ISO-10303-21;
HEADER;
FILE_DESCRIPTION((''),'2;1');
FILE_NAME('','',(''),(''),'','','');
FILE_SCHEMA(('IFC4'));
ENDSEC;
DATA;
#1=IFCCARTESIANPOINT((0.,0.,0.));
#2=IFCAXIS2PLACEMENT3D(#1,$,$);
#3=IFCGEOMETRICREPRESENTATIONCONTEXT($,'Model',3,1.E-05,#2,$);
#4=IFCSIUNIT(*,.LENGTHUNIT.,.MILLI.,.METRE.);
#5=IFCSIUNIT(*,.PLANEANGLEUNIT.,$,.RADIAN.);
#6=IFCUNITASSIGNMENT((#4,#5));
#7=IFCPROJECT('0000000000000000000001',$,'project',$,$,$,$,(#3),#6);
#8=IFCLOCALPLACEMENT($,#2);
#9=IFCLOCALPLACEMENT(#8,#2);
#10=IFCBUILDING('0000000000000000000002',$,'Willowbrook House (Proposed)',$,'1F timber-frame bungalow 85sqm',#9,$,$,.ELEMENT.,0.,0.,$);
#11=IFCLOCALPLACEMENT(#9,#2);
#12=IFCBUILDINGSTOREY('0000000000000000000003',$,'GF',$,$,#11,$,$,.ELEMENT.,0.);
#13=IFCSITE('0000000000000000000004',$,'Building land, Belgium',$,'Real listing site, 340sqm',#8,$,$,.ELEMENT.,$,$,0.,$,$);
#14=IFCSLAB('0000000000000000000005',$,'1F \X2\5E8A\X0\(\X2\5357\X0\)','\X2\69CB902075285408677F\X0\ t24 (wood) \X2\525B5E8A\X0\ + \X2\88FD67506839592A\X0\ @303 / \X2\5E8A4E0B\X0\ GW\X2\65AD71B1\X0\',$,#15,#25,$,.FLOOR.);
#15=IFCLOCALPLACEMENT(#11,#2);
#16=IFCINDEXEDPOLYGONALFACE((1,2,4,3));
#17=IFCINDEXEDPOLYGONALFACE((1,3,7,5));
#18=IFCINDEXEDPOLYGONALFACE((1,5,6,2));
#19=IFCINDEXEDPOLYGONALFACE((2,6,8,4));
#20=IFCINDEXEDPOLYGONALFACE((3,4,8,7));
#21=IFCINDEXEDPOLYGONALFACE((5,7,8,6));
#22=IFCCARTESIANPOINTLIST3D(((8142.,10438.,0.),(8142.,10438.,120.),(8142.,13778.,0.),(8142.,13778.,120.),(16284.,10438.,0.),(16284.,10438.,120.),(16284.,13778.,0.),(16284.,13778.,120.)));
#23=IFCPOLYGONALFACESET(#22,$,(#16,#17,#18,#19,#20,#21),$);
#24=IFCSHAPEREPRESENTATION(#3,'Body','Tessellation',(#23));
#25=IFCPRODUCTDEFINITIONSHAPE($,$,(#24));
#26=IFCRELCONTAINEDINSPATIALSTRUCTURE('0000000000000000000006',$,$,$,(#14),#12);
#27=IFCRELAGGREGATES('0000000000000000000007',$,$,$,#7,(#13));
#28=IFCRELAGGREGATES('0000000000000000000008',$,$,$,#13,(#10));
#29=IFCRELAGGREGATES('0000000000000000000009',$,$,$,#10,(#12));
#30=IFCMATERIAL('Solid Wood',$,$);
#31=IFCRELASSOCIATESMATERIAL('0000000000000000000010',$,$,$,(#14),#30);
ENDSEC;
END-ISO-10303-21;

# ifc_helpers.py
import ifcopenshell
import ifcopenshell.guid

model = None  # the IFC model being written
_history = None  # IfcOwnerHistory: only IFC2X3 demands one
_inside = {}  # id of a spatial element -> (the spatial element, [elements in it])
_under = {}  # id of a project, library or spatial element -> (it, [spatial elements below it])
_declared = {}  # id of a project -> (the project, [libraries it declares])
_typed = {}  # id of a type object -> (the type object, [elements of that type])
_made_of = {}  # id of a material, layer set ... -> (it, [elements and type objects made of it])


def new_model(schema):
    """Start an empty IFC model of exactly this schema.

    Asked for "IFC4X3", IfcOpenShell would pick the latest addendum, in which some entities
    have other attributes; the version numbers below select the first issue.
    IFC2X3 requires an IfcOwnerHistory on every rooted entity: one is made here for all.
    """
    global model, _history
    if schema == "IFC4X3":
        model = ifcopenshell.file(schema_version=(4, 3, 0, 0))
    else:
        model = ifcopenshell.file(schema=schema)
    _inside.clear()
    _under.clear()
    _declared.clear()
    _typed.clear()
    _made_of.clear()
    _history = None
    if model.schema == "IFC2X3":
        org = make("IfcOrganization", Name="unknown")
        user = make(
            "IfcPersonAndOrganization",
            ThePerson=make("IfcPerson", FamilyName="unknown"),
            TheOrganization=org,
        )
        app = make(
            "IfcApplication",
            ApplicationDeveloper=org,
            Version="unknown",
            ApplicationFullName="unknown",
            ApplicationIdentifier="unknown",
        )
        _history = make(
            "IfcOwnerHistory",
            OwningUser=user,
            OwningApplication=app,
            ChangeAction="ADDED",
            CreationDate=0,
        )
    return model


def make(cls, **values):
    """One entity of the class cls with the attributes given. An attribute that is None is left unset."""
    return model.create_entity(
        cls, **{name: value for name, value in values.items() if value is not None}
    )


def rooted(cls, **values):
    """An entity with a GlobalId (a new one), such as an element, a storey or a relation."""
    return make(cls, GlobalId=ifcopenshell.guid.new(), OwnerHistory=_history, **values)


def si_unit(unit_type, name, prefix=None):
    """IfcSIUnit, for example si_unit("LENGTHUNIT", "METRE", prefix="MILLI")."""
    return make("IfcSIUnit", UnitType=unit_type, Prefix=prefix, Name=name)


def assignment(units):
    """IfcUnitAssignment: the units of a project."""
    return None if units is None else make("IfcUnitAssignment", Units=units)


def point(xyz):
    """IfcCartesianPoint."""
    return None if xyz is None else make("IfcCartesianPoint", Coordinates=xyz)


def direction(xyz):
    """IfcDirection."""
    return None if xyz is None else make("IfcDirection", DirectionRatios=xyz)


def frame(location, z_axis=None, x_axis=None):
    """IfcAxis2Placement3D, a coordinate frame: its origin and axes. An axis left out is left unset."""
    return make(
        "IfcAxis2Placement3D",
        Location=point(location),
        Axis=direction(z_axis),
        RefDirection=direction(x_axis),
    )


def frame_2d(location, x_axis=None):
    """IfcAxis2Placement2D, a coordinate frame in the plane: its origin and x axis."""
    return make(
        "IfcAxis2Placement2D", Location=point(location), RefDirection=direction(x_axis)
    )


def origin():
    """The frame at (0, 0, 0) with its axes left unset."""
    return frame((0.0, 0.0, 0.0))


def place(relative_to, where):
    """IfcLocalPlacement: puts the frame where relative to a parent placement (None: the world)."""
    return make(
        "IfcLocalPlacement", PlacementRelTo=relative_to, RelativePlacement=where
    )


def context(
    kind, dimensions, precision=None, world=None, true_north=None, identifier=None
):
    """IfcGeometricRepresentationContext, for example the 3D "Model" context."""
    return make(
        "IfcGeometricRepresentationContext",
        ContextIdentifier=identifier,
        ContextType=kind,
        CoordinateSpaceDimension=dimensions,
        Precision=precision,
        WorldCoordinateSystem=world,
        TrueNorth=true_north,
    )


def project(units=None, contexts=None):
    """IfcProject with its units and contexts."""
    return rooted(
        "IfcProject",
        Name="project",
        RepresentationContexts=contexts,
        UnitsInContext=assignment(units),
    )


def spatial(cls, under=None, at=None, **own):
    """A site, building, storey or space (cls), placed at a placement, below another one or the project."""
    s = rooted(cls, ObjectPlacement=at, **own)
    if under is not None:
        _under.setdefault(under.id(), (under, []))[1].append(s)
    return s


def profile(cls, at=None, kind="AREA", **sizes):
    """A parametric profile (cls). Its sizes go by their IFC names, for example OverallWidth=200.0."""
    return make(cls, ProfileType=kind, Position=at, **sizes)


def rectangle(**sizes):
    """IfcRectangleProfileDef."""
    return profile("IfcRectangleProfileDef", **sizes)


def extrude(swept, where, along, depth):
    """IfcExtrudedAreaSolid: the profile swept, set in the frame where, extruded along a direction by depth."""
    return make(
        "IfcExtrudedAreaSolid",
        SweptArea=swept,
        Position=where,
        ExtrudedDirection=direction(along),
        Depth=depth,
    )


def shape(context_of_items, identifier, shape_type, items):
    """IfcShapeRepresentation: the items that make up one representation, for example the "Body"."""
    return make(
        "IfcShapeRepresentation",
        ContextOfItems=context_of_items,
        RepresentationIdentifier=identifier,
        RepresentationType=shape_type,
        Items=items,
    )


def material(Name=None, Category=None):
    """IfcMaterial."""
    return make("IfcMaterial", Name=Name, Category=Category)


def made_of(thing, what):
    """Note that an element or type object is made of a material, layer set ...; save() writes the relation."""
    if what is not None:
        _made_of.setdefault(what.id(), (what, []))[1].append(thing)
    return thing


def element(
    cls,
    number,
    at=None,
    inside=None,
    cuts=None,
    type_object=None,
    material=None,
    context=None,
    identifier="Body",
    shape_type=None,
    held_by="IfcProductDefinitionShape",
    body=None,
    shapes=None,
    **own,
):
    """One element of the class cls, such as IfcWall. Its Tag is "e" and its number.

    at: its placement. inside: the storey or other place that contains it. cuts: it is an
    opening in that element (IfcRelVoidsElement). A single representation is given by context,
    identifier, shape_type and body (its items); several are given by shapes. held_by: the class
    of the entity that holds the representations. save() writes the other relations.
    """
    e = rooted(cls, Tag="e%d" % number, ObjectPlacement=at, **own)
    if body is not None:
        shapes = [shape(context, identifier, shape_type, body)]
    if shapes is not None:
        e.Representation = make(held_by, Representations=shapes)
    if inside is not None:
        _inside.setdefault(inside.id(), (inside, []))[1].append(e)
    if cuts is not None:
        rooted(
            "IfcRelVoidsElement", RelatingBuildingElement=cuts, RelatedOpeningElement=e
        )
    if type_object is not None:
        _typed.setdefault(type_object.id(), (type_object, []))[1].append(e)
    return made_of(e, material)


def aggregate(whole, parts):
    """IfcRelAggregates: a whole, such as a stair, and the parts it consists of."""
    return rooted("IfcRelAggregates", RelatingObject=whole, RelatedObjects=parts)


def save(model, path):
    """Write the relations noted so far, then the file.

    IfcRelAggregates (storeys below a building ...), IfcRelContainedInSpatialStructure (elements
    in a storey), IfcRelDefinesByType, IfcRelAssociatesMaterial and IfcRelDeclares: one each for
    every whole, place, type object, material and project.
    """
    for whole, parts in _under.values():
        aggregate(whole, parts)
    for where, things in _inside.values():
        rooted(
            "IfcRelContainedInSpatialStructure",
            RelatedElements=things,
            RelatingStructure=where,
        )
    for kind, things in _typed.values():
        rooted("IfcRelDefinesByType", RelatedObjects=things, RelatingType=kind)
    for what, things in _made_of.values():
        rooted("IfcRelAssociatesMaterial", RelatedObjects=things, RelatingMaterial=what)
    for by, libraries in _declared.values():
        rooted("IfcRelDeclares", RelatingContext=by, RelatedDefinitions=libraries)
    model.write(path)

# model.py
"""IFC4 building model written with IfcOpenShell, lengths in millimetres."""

from ifc_helpers import new_model, si_unit, frame, frame_2d, origin, place, context, project, spatial, rectangle, extrude, material, element, save


model = new_model("IFC4")

# Units and contexts
model_context = context("Model", 3, precision=1e-05, world=origin())
ifc_project = project(units=[si_unit("LENGTHUNIT", "METRE", prefix="MILLI"), si_unit("PLANEANGLEUNIT", "RADIAN")], contexts=[model_context])

# Site, building, storey
site_placement = place(None, origin())
site = spatial("IfcSite", under=ifc_project, at=site_placement, Name="Building land, Belgium", ObjectType="Real listing site, 340sqm", CompositionType="ELEMENT", RefElevation=0.0)
building_placement = place(site_placement, origin())
building = spatial("IfcBuilding", under=site, at=building_placement, Name="Willowbrook House (Proposed)", ObjectType="1F timber-frame bungalow 85sqm", CompositionType="ELEMENT", ElevationOfRefHeight=0.0, ElevationOfTerrain=0.0)
storey_placement = place(building_placement, origin())
storey = spatial("IfcBuildingStorey", under=building, at=storey_placement, Name="GF", CompositionType="ELEMENT", Elevation=0.0)

# Shared definitions
ifc_material_1 = material(Name="Solid Wood")

# Slab
slab_1_placement = place(storey_placement, frame((4071.0, 5219.0, 0.0)))
element("IfcSlab", 1, at=slab_1_placement, inside=storey, material=ifc_material_1, Name="1F 床(南)", Description="構造用合板 t24 (wood) 剛床 + 製材根太 @303 / 床下 GW断熱", PredefinedType="FLOOR", context=model_context, shape_type="SweptSolid", body=[
    extrude(rectangle(XDim=8142.0, YDim=3340.0, at=frame_2d((4071.0, 1670.0))), frame((4071.0, 5219.0, 0.0)), (0.0, 0.0, 1.0), 120.0),
])

save(model, "model.ifc")
